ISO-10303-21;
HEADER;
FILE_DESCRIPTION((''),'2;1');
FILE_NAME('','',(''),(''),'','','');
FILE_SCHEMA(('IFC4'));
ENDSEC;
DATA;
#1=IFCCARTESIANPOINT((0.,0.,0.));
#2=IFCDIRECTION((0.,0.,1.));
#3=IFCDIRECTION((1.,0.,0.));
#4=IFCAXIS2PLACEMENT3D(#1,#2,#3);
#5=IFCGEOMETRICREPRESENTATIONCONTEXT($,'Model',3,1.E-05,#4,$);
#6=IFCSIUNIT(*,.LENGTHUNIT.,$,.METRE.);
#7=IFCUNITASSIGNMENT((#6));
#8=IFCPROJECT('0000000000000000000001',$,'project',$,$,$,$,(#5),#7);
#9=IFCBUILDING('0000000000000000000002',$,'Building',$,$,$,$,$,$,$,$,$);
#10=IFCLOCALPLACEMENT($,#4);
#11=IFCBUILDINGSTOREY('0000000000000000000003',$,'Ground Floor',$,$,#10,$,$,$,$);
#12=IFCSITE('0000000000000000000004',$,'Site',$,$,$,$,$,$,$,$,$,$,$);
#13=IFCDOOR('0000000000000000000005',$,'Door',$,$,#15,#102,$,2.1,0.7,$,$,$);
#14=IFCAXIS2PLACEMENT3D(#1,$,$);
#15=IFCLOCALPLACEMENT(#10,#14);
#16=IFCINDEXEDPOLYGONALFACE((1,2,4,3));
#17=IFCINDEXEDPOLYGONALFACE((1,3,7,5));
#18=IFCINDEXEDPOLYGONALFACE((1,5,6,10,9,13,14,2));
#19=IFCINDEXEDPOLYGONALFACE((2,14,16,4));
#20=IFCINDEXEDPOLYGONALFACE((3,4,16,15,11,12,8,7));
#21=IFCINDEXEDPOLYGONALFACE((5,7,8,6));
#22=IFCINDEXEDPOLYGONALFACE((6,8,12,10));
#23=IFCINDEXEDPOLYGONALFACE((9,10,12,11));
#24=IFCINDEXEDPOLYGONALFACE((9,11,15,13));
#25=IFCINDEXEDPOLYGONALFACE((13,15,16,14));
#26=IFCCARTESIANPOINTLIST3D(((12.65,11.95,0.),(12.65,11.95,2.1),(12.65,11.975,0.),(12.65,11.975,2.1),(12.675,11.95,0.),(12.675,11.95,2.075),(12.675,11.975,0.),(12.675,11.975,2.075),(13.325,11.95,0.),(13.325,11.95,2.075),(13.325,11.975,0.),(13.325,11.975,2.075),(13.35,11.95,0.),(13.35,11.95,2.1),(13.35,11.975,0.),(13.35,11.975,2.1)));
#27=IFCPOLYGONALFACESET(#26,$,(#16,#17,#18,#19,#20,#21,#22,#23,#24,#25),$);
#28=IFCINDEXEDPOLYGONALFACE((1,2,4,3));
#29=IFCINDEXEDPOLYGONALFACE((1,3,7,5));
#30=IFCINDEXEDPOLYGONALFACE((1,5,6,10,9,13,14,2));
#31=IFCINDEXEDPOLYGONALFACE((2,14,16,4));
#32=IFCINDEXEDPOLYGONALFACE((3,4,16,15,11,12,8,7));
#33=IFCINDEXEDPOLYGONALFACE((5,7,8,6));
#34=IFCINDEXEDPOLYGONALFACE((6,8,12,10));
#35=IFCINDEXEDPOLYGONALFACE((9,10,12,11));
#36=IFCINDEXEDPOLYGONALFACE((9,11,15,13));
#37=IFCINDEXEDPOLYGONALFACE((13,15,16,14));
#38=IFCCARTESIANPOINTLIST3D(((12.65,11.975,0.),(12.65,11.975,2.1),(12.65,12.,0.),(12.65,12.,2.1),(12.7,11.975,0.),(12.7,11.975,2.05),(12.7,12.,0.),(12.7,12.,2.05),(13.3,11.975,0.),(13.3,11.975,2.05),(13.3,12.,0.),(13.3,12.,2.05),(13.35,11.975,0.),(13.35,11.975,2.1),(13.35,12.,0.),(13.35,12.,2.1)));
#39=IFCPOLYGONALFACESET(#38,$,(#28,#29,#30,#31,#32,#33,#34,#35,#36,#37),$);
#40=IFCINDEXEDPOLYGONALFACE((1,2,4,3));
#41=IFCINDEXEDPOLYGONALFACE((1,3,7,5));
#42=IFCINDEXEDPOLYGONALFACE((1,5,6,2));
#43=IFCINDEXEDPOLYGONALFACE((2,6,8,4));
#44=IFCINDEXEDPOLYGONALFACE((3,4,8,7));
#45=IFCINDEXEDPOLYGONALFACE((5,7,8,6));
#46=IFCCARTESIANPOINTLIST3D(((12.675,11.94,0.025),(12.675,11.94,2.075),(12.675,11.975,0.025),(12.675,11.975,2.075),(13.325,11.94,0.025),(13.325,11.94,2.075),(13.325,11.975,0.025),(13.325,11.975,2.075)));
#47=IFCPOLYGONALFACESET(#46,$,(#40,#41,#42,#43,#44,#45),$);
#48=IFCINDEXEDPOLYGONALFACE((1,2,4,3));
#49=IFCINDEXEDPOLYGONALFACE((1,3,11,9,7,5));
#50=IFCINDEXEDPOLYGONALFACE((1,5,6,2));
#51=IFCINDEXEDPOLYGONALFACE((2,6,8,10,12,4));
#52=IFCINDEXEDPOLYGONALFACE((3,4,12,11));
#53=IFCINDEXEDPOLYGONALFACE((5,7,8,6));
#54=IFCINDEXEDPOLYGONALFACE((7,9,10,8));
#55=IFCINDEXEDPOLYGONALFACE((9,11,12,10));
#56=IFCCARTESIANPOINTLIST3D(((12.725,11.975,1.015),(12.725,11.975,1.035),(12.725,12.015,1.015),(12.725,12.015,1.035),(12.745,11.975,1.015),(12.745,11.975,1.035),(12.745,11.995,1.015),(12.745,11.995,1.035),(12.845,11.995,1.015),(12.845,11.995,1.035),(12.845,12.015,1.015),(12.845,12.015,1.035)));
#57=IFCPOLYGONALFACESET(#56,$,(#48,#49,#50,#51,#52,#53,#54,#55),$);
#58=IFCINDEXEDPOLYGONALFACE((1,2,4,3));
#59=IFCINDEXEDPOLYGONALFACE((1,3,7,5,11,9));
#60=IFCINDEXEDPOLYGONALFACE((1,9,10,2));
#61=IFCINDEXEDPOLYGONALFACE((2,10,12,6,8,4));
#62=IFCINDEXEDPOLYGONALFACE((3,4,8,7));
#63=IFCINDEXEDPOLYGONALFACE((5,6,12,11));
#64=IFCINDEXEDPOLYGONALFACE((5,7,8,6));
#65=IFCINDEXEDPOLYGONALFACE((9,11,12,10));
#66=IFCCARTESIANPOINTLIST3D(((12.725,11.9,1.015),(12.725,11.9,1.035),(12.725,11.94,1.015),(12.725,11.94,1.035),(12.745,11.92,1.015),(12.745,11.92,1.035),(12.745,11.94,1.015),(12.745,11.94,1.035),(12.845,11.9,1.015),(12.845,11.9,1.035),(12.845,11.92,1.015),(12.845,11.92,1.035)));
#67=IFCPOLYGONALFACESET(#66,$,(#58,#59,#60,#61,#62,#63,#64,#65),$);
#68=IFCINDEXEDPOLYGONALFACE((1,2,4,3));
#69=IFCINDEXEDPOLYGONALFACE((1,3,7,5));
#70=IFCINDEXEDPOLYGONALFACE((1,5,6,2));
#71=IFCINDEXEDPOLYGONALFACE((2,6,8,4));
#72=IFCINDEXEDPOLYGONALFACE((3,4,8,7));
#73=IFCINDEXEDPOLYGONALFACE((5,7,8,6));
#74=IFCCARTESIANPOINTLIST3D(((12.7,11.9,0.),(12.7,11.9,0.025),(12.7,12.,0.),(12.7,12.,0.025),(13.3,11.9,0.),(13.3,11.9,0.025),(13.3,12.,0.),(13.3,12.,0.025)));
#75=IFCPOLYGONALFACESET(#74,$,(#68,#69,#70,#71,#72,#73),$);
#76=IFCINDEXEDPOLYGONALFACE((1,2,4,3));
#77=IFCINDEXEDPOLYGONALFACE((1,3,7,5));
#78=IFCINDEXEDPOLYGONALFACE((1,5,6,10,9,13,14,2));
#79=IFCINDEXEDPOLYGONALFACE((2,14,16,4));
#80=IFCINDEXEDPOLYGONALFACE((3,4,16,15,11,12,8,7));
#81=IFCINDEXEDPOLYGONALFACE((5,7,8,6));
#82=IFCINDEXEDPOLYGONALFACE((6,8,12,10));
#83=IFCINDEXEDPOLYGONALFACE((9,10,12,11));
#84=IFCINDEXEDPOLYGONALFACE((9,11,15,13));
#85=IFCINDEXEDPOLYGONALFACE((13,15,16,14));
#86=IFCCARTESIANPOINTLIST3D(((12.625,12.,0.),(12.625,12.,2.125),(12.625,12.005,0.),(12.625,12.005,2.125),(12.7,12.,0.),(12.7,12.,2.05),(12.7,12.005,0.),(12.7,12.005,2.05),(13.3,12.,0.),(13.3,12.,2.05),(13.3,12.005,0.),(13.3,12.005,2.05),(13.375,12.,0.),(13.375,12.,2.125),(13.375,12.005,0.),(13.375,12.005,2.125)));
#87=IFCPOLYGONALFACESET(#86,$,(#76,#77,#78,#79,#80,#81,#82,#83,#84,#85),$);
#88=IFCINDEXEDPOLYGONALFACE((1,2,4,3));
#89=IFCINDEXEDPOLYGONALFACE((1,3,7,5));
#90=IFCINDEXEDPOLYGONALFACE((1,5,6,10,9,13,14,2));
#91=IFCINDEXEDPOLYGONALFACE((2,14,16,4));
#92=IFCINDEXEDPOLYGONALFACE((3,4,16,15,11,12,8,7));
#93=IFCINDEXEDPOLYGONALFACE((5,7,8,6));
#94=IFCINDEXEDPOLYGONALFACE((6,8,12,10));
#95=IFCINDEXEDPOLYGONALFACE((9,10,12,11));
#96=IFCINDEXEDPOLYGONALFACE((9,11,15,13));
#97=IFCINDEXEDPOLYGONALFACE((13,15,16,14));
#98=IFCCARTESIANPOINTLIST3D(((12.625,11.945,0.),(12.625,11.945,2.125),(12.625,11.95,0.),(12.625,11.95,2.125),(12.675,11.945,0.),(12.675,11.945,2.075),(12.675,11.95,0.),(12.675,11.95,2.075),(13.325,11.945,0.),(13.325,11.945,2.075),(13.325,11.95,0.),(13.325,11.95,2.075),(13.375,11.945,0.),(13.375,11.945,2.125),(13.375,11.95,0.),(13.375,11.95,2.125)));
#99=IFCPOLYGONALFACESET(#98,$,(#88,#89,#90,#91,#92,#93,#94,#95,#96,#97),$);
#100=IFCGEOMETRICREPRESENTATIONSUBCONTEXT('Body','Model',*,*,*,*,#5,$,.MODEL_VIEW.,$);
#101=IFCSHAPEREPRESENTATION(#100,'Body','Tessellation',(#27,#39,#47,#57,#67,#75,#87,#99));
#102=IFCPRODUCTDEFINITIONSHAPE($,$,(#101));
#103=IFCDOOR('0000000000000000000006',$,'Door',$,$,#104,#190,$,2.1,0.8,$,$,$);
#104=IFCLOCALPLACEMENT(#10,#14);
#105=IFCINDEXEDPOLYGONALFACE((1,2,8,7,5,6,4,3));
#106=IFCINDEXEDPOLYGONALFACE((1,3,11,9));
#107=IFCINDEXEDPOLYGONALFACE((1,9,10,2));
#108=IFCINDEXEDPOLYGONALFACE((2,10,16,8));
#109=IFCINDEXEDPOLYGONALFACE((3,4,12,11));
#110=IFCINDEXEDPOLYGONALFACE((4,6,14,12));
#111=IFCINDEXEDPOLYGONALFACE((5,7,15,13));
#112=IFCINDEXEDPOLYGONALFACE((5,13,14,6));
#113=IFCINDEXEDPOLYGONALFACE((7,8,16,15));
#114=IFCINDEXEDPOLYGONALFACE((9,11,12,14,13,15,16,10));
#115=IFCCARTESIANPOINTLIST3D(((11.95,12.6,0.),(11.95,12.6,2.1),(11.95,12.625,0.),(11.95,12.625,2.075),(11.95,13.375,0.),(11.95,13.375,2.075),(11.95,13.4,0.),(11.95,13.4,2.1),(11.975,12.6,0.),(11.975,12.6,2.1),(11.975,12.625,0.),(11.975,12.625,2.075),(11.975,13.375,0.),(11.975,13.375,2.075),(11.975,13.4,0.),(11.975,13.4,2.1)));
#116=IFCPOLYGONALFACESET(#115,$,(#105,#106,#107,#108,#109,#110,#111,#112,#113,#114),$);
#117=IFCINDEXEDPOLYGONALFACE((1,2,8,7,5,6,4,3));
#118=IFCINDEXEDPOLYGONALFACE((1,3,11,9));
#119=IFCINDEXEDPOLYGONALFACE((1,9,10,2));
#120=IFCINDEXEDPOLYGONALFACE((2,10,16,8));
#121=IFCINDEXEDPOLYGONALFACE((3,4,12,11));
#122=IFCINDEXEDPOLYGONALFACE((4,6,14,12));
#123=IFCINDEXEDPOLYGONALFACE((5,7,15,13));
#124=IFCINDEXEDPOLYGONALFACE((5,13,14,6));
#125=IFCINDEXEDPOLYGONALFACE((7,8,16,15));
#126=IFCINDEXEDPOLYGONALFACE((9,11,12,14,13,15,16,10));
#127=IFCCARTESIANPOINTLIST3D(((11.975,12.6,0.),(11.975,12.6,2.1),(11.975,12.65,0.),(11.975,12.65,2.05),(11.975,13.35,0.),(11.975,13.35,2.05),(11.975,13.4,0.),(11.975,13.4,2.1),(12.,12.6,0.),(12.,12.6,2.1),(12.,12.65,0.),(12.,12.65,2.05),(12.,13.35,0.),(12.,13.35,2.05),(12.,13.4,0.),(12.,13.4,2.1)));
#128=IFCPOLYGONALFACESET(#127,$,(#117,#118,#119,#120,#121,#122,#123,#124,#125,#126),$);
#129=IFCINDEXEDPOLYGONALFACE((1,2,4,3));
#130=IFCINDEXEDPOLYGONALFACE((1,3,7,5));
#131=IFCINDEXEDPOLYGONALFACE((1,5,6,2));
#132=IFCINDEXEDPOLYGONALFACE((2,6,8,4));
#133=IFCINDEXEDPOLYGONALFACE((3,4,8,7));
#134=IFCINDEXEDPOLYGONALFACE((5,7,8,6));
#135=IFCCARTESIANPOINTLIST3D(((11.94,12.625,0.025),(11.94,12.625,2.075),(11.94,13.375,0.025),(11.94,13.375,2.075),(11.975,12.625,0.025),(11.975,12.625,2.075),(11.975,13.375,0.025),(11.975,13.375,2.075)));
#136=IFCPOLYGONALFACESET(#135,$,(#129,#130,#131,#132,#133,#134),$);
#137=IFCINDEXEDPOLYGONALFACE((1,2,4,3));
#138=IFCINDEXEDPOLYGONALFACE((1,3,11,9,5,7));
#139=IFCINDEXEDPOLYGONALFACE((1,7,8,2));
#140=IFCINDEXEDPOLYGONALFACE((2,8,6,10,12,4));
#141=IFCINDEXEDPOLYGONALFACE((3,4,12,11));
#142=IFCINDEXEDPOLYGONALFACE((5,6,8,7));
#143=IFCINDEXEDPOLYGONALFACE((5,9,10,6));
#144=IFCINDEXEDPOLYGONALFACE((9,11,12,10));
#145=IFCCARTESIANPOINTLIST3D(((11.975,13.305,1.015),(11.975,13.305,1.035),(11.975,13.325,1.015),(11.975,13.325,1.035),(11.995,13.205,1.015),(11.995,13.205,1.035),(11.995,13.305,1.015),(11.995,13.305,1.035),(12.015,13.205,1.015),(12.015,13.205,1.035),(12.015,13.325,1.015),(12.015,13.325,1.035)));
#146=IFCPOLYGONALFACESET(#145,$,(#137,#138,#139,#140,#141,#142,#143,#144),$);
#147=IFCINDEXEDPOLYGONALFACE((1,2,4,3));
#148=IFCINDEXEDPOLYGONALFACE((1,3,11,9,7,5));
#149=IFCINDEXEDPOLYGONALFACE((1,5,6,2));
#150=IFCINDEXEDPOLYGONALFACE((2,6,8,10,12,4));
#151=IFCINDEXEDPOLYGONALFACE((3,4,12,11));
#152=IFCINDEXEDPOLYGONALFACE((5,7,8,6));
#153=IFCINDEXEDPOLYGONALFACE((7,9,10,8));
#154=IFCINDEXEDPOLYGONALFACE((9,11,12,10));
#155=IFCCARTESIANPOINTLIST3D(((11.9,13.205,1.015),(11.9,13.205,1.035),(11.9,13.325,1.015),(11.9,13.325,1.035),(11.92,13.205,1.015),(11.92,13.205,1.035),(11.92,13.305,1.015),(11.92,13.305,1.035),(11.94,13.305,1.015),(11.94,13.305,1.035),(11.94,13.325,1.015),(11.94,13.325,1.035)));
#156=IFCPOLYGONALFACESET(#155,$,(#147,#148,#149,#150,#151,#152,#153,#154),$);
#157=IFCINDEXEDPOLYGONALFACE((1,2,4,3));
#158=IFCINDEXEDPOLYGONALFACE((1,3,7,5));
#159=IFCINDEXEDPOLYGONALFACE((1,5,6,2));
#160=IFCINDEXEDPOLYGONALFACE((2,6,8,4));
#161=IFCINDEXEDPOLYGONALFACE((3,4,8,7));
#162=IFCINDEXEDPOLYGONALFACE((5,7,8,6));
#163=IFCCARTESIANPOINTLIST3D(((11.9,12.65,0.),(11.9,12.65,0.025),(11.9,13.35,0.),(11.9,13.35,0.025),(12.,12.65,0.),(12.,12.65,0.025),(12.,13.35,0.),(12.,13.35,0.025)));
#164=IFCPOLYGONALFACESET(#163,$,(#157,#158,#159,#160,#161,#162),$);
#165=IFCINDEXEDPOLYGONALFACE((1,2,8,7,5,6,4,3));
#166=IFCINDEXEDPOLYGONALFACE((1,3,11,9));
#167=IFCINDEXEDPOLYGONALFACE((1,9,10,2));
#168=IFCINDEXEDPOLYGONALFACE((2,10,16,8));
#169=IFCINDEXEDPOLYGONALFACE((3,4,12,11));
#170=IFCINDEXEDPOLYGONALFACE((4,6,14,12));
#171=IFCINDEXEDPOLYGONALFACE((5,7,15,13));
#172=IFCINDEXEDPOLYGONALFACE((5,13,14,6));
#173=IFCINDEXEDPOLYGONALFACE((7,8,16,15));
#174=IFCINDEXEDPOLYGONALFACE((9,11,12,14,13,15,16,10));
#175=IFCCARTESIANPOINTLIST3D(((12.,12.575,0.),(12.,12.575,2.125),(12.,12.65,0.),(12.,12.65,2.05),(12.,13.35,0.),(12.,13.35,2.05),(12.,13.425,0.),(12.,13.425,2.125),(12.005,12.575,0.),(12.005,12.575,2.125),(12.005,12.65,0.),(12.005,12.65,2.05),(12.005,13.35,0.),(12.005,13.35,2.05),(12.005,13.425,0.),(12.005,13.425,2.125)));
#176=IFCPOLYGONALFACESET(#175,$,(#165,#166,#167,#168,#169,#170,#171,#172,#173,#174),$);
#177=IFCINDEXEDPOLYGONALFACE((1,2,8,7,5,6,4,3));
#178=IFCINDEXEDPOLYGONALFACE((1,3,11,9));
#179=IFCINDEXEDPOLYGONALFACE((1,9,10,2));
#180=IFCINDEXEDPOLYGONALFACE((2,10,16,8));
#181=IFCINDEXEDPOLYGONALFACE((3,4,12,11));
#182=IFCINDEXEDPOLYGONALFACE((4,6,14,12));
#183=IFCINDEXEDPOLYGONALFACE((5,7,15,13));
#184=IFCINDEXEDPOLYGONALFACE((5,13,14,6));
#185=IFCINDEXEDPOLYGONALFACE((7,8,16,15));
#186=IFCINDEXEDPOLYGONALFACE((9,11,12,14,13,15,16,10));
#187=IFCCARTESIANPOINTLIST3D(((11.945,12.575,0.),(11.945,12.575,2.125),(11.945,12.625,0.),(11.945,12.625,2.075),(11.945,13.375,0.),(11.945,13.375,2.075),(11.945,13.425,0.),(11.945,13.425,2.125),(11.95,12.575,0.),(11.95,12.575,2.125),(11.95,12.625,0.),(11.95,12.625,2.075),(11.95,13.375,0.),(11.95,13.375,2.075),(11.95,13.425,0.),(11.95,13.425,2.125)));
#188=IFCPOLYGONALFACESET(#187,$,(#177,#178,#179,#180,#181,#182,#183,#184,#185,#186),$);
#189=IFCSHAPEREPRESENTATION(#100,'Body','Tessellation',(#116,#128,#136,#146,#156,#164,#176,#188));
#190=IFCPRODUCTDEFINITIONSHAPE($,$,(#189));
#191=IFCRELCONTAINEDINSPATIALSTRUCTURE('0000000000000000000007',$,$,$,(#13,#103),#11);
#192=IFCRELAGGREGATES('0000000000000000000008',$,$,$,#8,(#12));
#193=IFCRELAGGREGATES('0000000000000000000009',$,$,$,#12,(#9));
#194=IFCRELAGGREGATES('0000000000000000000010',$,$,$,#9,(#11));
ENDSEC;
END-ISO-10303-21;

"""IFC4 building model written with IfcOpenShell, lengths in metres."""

from ifc_helpers import new_model, si_unit, frame, origin_with_axes, place, context, subcontext, project, spatial, line, indexed_curve, outline, extrude, element, save


model = new_model("IFC4")

# Units and contexts
model_context = context("Model", 3, precision=1e-05, world=origin_with_axes())
body_context = subcontext(model_context, "Body", "Model", "MODEL_VIEW")
ifc_project = project(units=[si_unit("LENGTHUNIT", "METRE")], contexts=[model_context])

# Site, building, storey
site = spatial("IfcSite", under=ifc_project, Name="Site")
building = spatial("IfcBuilding", under=site, Name="Building")
storey_placement = place(None, origin_with_axes())
storey = spatial("IfcBuildingStorey", under=building, at=storey_placement, Name="Ground Floor")

# Doors
door_1_placement = place(storey_placement, frame((13.35, 12.0, 0.0), z_axis=(0.0, 0.0, 1.0), x_axis=(-1.0, 0.0, 0.0)))
element("IfcDoor", 1, at=door_1_placement, inside=storey, Name="Door", OverallHeight=2.1, OverallWidth=0.7, context=body_context, shape_type="SweptSolid", body=[
    extrude(outline(indexed_curve([(0.0, 0.0), (0.0, 2.1), (0.7, 2.1), (0.7, 0.0), (0.675, 0.0), (0.675, 2.075), (0.025, 2.075), (0.025, 0.0)], segments=[line(1, 2, 3, 4, 5, 6, 7, 8, 1)])), frame((0.0, 0.025, 0.0), z_axis=(0.0, -1.0, 0.0), x_axis=(1.0, 0.0, 0.0)), (0.0, 0.0, -1.0), 0.025),
    extrude(outline(indexed_curve([(0.0, 0.0), (0.0, 2.1), (0.7, 2.1), (0.7, 0.0), (0.65, 0.0), (0.65, 2.05), (0.05, 2.05), (0.05, 0.0)], segments=[line(1, 2, 3, 4, 5, 6, 7, 8, 1)])), frame((0.0, 0.0, 0.0), z_axis=(0.0, -1.0, 0.0), x_axis=(1.0, 0.0, 0.0)), (0.0, 0.0, -1.0), 0.025),
    extrude(outline(indexed_curve([(0.0, 0.0), (0.65, 0.0), (0.65, 0.035), (0.0, 0.035)], segments=[line(1, 2, 3, 4, 1)])), frame((0.025, 0.025, 0.025), z_axis=(0.0, 0.0, 1.0), x_axis=(1.0, 0.0, 0.0)), (0.0, 0.0, 1.0), 2.05),
    extrude(outline(indexed_curve([(0.0, 0.0), (0.0, -0.04), (-0.12, -0.04), (-0.12, -0.02), (-0.02, -0.02), (-0.02, 0.0)], segments=[line(1, 2, 3, 4, 5, 6, 1)])), frame((0.625, 0.025, 1.015), z_axis=(0.0, 0.0, 1.0), x_axis=(1.0, 0.0, 0.0)), (0.0, 0.0, 1.0), 0.02),
    extrude(outline(indexed_curve([(0.0, 0.0), (0.0, 0.04), (-0.12, 0.04), (-0.12, 0.02), (-0.02, 0.02), (-0.02, 0.0)], segments=[line(1, 2, 3, 4, 5, 6, 1)])), frame((0.625, 0.06, 1.015), z_axis=(0.0, 0.0, 1.0), x_axis=(1.0, 0.0, 0.0)), (0.0, 0.0, 1.0), 0.02),
    extrude(outline(indexed_curve([(0.0, 0.0), (0.6, 0.0), (0.6, 0.1), (0.0, 0.1)], segments=[line(1, 2, 3, 4, 1)])), frame((0.05, 0.0, 0.0), z_axis=(0.0, 0.0, 1.0), x_axis=(1.0, 0.0, 0.0)), (0.0, 0.0, 1.0), 0.025),
    extrude(outline(indexed_curve([(0.0, 0.0), (0.0, 2.125), (0.75, 2.125), (0.75, 0.0), (0.675, 0.0), (0.675, 2.05), (0.075, 2.05), (0.075, 0.0)], segments=[line(1, 2, 3, 4, 5, 6, 7, 8, 1)])), frame((-0.025, -0.005, 0.0), z_axis=(0.0, -1.0, 0.0), x_axis=(1.0, 0.0, 0.0)), (0.0, 0.0, -1.0), 0.005),
    extrude(outline(indexed_curve([(0.0, 0.0), (0.0, 2.125), (0.75, 2.125), (0.75, 0.0), (0.7, 0.0), (0.7, 2.075), (0.05, 2.075), (0.05, 0.0)], segments=[line(1, 2, 3, 4, 5, 6, 7, 8, 1)])), frame((-0.025, 0.05, 0.0), z_axis=(0.0, -1.0, 0.0), x_axis=(1.0, 0.0, 0.0)), (0.0, 0.0, -1.0), 0.005),
])
door_2_placement = place(storey_placement, frame((12.0, 12.6, 0.0), z_axis=(0.0, 0.0, 1.0), x_axis=(0.0, 1.0, 0.0)))
element("IfcDoor", 2, at=door_2_placement, inside=storey, Name="Door", OverallHeight=2.1, OverallWidth=0.8, context=body_context, shape_type="SweptSolid", body=[
    extrude(outline(indexed_curve([(0.0, 0.0), (0.0, 2.1), (0.8, 2.1), (0.8, 0.0), (0.775, 0.0), (0.775, 2.075), (0.025, 2.075), (0.025, 0.0)], segments=[line(1, 2, 3, 4, 5, 6, 7, 8, 1)])), frame((0.0, 0.025, 0.0), z_axis=(0.0, -1.0, 0.0), x_axis=(1.0, 0.0, 0.0)), (0.0, 0.0, -1.0), 0.025),
    extrude(outline(indexed_curve([(0.0, 0.0), (0.0, 2.1), (0.8, 2.1), (0.8, 0.0), (0.75, 0.0), (0.75, 2.05), (0.05, 2.05), (0.05, 0.0)], segments=[line(1, 2, 3, 4, 5, 6, 7, 8, 1)])), frame((0.0, 0.0, 0.0), z_axis=(0.0, -1.0, 0.0), x_axis=(1.0, 0.0, 0.0)), (0.0, 0.0, -1.0), 0.025),
    extrude(outline(indexed_curve([(0.0, 0.0), (0.75, 0.0), (0.75, 0.035), (0.0, 0.035)], segments=[line(1, 2, 3, 4, 1)])), frame((0.025, 0.025, 0.025), z_axis=(0.0, 0.0, 1.0), x_axis=(1.0, 0.0, 0.0)), (0.0, 0.0, 1.0), 2.05),
    extrude(outline(indexed_curve([(0.0, 0.0), (0.0, -0.04), (-0.12, -0.04), (-0.12, -0.02), (-0.02, -0.02), (-0.02, 0.0)], segments=[line(1, 2, 3, 4, 5, 6, 1)])), frame((0.725, 0.025, 1.015), z_axis=(0.0, 0.0, 1.0), x_axis=(1.0, 0.0, 0.0)), (0.0, 0.0, 1.0), 0.02),
    extrude(outline(indexed_curve([(0.0, 0.0), (0.0, 0.04), (-0.12, 0.04), (-0.12, 0.02), (-0.02, 0.02), (-0.02, 0.0)], segments=[line(1, 2, 3, 4, 5, 6, 1)])), frame((0.725, 0.06, 1.015), z_axis=(0.0, 0.0, 1.0), x_axis=(1.0, 0.0, 0.0)), (0.0, 0.0, 1.0), 0.02),
    extrude(outline(indexed_curve([(0.0, 0.0), (0.7, 0.0), (0.7, 0.1), (0.0, 0.1)], segments=[line(1, 2, 3, 4, 1)])), frame((0.05, 0.0, 0.0), z_axis=(0.0, 0.0, 1.0), x_axis=(1.0, 0.0, 0.0)), (0.0, 0.0, 1.0), 0.025),
    extrude(outline(indexed_curve([(0.0, 0.0), (0.0, 2.125), (0.85, 2.125), (0.85, 0.0), (0.775, 0.0), (0.775, 2.05), (0.075, 2.05), (0.075, 0.0)], segments=[line(1, 2, 3, 4, 5, 6, 7, 8, 1)])), frame((-0.025, -0.005, 0.0), z_axis=(0.0, -1.0, 0.0), x_axis=(1.0, 0.0, 0.0)), (0.0, 0.0, -1.0), 0.005),
    extrude(outline(indexed_curve([(0.0, 0.0), (0.0, 2.125), (0.85, 2.125), (0.85, 0.0), (0.8, 0.0), (0.8, 2.075), (0.05, 2.075), (0.05, 0.0)], segments=[line(1, 2, 3, 4, 5, 6, 7, 8, 1)])), frame((-0.025, 0.05, 0.0), z_axis=(0.0, -1.0, 0.0), x_axis=(1.0, 0.0, 0.0)), (0.0, 0.0, -1.0), 0.005),
])

save(model, "model.ifc")
